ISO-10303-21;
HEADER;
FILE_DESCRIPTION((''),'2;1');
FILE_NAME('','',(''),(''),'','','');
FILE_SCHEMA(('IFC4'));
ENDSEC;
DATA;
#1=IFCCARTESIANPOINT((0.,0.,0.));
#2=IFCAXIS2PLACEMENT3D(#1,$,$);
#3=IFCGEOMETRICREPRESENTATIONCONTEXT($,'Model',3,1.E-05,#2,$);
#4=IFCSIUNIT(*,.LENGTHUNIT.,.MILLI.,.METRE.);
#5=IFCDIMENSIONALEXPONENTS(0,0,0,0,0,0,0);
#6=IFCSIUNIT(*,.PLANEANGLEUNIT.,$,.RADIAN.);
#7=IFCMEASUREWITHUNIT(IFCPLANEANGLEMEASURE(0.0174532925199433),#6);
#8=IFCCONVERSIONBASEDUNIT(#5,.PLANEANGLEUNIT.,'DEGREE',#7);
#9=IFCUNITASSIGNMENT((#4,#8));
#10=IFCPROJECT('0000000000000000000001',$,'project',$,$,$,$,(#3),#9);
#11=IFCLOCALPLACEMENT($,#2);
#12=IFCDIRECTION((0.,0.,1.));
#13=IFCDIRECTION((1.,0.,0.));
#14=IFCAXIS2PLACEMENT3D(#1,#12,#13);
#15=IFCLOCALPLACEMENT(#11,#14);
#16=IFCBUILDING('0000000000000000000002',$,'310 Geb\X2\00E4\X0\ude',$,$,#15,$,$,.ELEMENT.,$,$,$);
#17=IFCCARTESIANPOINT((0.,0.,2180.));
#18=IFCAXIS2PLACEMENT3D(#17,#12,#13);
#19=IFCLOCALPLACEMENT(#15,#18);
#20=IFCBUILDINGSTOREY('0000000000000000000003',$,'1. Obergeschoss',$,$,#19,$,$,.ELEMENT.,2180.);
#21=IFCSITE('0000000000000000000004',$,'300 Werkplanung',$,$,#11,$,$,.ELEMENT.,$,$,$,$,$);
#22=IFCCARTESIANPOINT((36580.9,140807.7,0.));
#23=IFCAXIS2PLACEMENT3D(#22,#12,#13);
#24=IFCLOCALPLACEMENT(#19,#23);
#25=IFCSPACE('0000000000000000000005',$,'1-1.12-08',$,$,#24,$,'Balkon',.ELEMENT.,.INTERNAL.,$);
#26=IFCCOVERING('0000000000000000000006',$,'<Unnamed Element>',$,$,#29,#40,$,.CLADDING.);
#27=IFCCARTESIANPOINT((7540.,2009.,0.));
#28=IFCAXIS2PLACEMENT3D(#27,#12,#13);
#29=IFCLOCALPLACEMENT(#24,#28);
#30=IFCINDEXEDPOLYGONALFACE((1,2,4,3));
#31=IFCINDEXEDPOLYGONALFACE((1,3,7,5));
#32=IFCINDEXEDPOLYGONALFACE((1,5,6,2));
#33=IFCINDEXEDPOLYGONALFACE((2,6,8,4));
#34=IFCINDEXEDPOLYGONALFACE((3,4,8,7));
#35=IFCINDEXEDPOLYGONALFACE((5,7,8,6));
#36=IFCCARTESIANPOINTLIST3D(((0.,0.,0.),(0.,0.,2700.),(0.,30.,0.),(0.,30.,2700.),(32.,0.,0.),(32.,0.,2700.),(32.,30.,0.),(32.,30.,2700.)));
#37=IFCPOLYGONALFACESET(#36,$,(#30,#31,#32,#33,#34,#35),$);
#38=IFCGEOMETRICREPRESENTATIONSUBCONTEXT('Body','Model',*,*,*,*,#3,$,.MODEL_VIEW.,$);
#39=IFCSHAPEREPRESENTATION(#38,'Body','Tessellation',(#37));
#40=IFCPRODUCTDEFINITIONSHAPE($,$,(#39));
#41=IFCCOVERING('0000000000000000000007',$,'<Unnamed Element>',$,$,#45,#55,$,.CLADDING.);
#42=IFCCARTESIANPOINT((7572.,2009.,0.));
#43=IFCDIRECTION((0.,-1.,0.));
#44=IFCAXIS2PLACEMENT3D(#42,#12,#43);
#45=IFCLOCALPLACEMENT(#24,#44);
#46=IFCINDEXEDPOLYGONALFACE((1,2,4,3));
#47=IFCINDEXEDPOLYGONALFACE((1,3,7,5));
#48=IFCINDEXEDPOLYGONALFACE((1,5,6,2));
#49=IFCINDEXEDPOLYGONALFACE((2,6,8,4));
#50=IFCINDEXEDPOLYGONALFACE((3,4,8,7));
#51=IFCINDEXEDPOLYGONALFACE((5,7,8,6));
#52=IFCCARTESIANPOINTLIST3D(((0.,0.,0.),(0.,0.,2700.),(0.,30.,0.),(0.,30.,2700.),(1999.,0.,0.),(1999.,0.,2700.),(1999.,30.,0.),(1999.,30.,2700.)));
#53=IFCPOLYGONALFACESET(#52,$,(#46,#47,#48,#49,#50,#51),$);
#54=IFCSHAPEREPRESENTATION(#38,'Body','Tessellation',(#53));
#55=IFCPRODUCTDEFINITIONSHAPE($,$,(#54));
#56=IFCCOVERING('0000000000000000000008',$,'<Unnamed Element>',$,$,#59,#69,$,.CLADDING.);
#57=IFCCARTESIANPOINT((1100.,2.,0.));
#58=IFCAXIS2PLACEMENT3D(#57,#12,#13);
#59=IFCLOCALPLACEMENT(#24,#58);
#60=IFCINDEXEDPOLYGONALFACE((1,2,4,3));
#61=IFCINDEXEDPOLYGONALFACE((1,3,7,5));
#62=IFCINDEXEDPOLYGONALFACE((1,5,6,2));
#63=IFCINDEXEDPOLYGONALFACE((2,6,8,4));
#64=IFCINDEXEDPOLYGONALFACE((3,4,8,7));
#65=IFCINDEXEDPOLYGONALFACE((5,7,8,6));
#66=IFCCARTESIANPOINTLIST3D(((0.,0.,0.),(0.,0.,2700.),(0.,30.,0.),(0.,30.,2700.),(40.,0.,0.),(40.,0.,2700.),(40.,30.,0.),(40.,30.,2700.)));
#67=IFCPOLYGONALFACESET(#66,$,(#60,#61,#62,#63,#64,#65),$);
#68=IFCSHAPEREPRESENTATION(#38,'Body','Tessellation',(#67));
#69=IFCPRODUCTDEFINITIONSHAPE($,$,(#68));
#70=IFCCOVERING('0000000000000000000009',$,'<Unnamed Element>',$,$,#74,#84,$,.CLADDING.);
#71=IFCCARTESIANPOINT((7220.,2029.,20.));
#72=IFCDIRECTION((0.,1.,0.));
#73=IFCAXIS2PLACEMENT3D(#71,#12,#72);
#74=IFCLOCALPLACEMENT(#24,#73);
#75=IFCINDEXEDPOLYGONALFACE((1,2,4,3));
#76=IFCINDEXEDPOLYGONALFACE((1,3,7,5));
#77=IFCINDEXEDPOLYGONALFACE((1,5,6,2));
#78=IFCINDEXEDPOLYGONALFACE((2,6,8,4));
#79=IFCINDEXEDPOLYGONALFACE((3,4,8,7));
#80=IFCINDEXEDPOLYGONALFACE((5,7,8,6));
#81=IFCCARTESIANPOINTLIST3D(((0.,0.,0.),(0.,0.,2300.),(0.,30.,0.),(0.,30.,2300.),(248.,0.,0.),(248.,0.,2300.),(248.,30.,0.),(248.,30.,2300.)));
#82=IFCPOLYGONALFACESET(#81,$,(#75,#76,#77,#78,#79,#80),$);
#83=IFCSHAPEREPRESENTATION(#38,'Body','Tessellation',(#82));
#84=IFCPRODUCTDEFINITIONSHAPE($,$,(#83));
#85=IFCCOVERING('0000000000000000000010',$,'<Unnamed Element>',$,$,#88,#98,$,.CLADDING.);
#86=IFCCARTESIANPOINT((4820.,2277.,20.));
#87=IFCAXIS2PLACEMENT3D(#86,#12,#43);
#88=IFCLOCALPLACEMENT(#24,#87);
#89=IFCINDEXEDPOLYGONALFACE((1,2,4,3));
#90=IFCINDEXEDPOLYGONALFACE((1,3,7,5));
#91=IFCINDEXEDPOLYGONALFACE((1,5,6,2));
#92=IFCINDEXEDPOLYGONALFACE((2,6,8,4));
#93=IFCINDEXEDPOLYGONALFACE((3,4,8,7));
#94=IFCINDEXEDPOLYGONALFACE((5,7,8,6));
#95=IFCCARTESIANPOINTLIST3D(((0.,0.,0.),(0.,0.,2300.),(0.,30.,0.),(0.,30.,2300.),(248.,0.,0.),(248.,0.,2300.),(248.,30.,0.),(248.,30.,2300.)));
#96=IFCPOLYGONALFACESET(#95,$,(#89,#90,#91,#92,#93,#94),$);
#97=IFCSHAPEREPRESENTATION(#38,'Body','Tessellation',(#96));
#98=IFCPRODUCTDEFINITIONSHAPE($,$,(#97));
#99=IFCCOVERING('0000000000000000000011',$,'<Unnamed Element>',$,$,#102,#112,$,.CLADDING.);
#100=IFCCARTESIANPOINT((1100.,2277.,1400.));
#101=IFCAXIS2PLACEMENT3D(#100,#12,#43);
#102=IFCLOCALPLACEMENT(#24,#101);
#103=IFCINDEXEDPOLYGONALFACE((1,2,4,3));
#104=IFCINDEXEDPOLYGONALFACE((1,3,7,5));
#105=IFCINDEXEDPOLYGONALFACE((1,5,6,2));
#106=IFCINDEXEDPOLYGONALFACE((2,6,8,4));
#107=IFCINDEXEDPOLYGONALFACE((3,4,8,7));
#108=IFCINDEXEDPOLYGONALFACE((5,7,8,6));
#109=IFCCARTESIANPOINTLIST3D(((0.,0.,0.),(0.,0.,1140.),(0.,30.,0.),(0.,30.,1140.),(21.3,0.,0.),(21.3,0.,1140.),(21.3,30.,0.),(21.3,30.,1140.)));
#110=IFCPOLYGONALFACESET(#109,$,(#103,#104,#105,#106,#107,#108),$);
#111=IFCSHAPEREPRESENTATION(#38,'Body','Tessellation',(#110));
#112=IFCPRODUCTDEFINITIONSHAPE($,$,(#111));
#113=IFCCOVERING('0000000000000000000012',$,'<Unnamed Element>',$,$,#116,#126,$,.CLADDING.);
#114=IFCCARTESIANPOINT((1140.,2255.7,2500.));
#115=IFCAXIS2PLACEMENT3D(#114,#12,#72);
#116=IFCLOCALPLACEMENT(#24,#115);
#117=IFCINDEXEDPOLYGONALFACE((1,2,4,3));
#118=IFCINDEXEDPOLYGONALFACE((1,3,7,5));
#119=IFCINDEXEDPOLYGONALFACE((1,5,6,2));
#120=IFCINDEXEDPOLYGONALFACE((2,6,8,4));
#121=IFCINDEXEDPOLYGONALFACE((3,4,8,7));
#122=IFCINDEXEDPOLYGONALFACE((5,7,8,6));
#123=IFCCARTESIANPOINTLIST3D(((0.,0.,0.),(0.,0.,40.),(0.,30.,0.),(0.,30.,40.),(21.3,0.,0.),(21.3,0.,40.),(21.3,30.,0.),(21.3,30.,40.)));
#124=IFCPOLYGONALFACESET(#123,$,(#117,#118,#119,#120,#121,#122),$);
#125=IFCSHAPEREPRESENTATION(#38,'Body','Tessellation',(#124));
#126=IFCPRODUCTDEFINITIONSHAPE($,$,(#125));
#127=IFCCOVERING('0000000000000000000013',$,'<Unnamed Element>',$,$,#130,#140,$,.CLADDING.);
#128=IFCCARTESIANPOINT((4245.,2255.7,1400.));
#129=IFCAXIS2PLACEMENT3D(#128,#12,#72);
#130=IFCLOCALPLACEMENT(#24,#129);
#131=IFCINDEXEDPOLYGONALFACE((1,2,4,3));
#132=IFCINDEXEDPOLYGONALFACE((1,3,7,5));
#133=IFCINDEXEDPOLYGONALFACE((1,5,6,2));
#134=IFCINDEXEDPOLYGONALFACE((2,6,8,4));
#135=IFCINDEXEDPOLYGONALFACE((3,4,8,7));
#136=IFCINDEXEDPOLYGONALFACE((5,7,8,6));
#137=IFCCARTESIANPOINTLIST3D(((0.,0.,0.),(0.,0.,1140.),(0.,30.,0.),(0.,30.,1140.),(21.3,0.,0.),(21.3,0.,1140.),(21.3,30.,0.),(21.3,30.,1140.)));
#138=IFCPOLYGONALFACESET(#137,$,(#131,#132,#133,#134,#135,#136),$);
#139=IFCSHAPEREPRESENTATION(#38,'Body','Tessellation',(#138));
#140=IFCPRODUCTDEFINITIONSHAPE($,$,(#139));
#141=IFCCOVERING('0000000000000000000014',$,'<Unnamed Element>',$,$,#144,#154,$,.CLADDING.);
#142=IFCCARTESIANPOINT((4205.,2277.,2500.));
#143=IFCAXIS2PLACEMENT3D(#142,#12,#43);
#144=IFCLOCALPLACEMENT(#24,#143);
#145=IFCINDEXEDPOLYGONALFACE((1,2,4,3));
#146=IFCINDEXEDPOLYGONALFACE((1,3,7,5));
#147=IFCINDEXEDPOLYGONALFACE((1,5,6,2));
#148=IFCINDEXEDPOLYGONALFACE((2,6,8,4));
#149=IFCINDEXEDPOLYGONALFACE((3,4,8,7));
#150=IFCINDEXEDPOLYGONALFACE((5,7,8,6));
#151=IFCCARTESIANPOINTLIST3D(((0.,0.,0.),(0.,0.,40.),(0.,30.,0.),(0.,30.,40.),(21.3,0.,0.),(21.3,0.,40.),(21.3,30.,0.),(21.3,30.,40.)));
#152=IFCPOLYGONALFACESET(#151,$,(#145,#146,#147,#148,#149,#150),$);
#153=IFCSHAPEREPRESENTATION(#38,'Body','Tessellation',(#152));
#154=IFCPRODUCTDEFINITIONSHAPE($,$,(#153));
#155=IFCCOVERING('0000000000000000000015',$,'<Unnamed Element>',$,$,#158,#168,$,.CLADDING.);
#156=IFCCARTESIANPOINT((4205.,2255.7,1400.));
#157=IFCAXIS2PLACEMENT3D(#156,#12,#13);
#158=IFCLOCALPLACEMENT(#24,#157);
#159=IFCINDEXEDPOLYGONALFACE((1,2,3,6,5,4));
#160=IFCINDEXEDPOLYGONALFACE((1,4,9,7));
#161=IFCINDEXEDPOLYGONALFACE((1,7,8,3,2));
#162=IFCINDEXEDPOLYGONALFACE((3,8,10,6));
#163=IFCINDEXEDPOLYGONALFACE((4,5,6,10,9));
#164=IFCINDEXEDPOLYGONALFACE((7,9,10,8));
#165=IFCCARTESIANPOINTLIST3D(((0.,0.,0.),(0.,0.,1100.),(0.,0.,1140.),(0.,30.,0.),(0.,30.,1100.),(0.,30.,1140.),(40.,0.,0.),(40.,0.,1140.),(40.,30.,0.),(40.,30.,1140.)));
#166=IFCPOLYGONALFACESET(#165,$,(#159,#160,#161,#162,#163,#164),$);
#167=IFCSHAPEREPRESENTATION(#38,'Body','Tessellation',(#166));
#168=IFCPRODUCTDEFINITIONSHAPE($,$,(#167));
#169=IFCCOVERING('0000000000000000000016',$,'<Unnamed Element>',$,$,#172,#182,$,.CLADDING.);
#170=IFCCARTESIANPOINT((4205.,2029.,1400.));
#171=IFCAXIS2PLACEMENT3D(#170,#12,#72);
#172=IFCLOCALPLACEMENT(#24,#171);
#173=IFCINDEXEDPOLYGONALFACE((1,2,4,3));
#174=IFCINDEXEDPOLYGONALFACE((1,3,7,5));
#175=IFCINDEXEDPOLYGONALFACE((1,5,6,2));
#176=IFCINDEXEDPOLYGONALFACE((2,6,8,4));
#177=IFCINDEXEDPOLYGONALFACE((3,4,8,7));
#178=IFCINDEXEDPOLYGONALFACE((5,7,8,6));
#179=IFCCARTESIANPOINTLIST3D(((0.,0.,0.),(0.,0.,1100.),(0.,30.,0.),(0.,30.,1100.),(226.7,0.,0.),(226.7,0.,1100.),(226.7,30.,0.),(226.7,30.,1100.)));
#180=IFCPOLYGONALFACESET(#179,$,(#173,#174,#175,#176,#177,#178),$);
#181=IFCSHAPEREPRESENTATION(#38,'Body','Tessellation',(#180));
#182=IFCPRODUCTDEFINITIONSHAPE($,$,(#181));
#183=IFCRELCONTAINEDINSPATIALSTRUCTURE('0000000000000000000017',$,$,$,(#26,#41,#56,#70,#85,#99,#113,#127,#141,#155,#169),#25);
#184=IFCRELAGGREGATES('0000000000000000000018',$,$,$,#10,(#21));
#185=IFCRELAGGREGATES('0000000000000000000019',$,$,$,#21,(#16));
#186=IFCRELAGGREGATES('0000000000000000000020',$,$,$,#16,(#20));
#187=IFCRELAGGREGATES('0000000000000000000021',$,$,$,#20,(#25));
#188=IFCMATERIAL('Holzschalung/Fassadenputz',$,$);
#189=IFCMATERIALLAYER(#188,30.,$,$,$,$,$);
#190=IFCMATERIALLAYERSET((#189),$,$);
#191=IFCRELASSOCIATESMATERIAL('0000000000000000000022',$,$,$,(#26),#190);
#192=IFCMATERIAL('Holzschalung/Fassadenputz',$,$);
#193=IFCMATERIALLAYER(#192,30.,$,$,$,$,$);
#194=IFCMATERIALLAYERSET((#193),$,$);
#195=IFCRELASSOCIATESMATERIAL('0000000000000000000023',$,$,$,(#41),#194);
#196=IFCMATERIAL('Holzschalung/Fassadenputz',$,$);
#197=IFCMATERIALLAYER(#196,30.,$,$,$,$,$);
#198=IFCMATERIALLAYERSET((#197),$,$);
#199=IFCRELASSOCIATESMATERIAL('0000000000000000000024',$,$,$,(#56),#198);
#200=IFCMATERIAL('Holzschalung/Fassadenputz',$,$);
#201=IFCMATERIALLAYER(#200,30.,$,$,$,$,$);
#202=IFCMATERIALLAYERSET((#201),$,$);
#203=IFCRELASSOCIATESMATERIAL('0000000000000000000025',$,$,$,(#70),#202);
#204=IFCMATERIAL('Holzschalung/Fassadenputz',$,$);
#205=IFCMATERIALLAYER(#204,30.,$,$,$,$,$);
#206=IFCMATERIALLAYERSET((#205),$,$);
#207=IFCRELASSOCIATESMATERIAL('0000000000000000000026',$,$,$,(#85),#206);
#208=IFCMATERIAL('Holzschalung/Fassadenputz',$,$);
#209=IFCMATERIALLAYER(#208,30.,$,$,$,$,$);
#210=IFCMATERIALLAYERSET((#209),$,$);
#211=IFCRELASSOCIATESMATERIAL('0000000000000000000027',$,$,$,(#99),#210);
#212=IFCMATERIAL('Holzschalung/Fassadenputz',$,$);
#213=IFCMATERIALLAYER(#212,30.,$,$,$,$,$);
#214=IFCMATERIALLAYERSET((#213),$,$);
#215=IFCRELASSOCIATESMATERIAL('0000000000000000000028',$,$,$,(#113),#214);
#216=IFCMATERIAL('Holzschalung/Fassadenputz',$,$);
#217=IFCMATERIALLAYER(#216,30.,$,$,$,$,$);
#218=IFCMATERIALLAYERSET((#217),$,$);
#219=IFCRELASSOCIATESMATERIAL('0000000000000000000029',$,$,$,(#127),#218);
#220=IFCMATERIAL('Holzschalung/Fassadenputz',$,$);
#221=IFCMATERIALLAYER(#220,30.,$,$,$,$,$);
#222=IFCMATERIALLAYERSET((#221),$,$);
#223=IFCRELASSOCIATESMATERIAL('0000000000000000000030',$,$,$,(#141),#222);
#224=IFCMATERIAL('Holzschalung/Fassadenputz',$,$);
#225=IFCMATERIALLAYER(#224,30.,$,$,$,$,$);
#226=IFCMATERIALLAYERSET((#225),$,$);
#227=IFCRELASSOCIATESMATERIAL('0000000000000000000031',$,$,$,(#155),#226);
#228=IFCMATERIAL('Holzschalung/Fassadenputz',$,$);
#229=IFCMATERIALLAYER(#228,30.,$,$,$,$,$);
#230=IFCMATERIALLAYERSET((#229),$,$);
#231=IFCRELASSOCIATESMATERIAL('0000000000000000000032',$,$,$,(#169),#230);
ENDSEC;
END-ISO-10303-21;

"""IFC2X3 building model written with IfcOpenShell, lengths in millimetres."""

from ifc_helpers import new_model, entity, si_unit, converted_unit, frame, frame_2d, origin, origin_with_axes, place, context, subcontext, project, spatial, polyline, rectangle, outline, extrude, material, layer, layer_set, layer_usage, element, save


model = new_model("IFC2X3")

# Units and contexts
model_context = context("Model", 3, precision=1e-05, world=origin())
body_context = subcontext(model_context, "Body", "Model", "MODEL_VIEW")
ifc_project = project(units=[si_unit("LENGTHUNIT", "METRE", prefix="MILLI"), converted_unit("PLANEANGLEUNIT", "DEGREE", entity("IfcPlaneAngleMeasure", 0.0174532925199433), si_unit("PLANEANGLEUNIT", "RADIAN"), dimensions=[0, 0, 0, 0, 0, 0, 0])], contexts=[model_context])

# Site, building, storey
site_placement = place(None, origin())
site = spatial("IfcSite", under=ifc_project, at=site_placement, Name="300 Werkplanung", CompositionType="ELEMENT")
building_placement = place(site_placement, origin_with_axes())
building = spatial("IfcBuilding", under=site, at=building_placement, Name="310 Gebäude", CompositionType="ELEMENT")
storey_placement = place(building_placement, frame((0.0, 0.0, 2180.0), z_axis=(0.0, 0.0, 1.0), x_axis=(1.0, 0.0, 0.0)))
storey = spatial("IfcBuildingStorey", under=building, at=storey_placement, Name="1. Obergeschoss", CompositionType="ELEMENT", Elevation=2180.0)

# Shared definitions
space_1_placement = place(storey_placement, frame((36580.9, 140807.7, 0.0), z_axis=(0.0, 0.0, 1.0), x_axis=(1.0, 0.0, 0.0)))
space_1 = spatial("IfcSpace", under=storey, at=space_1_placement, Name="1-1.12-08", LongName="Balkon", CompositionType="ELEMENT", InteriorOrExteriorSpace="INTERNAL")

# Coverings
ifc_material_1 = material(Name="Holzschalung/Fassadenputz")
ifc_layer_1 = layer(ifc_material_1, 30.0)
ifc_layer_set_1 = layer_set([ifc_layer_1])
ifc_layer_usage_1 = layer_usage(ifc_layer_set_1, "AXIS3", "POSITIVE", 0.0)
covering_1_placement = place(space_1_placement, frame((7540.0, 2009.0, 0.0), z_axis=(0.0, 0.0, 1.0), x_axis=(1.0, 0.0, 0.0)))
element("IfcCovering", 1, at=covering_1_placement, inside=space_1, material=ifc_layer_usage_1, Name="<Unnamed Element>", PredefinedType="CLADDING", context=body_context, shape_type="SweptSolid", body=[
    extrude(rectangle(XDim=32.0, YDim=2700.0, at=frame_2d((-16.0, -1350.0), x_axis=(-1.0, 0.0))), frame((32.0, 0.0, 0.0), z_axis=(0.0, 1.0, 0.0), x_axis=(1.0, 0.0, 0.0)), (0.0, 0.0, 1.0), 30.0),
])
ifc_material_2 = material(Name="Holzschalung/Fassadenputz")
ifc_layer_2 = layer(ifc_material_2, 30.0)
ifc_layer_set_2 = layer_set([ifc_layer_2])
ifc_layer_usage_2 = layer_usage(ifc_layer_set_2, "AXIS3", "POSITIVE", 0.0)
covering_2_placement = place(space_1_placement, frame((7572.0, 2009.0, 0.0), z_axis=(0.0, 0.0, 1.0), x_axis=(0.0, -1.0, 0.0)))
element("IfcCovering", 2, at=covering_2_placement, inside=space_1, material=ifc_layer_usage_2, Name="<Unnamed Element>", PredefinedType="CLADDING", context=body_context, shape_type="SweptSolid", body=[
    extrude(rectangle(XDim=1999.0, YDim=2700.0, at=frame_2d((-999.5, -1350.0), x_axis=(-1.0, 0.0))), frame((1999.0, 0.0, 0.0), z_axis=(0.0, 1.0, 0.0), x_axis=(1.0, 0.0, 0.0)), (0.0, 0.0, 1.0), 30.0),
])
ifc_material_3 = material(Name="Holzschalung/Fassadenputz")
ifc_layer_3 = layer(ifc_material_3, 30.0)
ifc_layer_set_3 = layer_set([ifc_layer_3])
ifc_layer_usage_3 = layer_usage(ifc_layer_set_3, "AXIS3", "POSITIVE", 0.0)
covering_3_placement = place(space_1_placement, frame((1100.0, 2.0, 0.0), z_axis=(0.0, 0.0, 1.0), x_axis=(1.0, 0.0, 0.0)))
element("IfcCovering", 3, at=covering_3_placement, inside=space_1, material=ifc_layer_usage_3, Name="<Unnamed Element>", PredefinedType="CLADDING", context=body_context, shape_type="SweptSolid", body=[
    extrude(rectangle(XDim=40.0, YDim=2700.0, at=frame_2d((-20.0, -1350.0), x_axis=(-1.0, 0.0))), frame((40.0, 0.0, 0.0), z_axis=(0.0, 1.0, 0.0), x_axis=(1.0, 0.0, 0.0)), (0.0, 0.0, 1.0), 30.0),
])
ifc_material_4 = material(Name="Holzschalung/Fassadenputz")
ifc_layer_4 = layer(ifc_material_4, 30.0)
ifc_layer_set_4 = layer_set([ifc_layer_4])
ifc_layer_usage_4 = layer_usage(ifc_layer_set_4, "AXIS3", "POSITIVE", 0.0)
covering_4_placement = place(space_1_placement, frame((7220.0, 2029.0, 20.0), z_axis=(0.0, 0.0, 1.0), x_axis=(0.0, 1.0, 0.0)))
element("IfcCovering", 4, at=covering_4_placement, inside=space_1, material=ifc_layer_usage_4, Name="<Unnamed Element>", PredefinedType="CLADDING", context=body_context, shape_type="SweptSolid", body=[
    extrude(rectangle(XDim=248.0, YDim=2300.0, at=frame_2d((-124.0, -1150.0), x_axis=(-1.0, 0.0))), frame((248.0, 0.0, 0.0), z_axis=(0.0, 1.0, 0.0), x_axis=(1.0, 0.0, 0.0)), (0.0, 0.0, 1.0), 30.0),
])
ifc_material_5 = material(Name="Holzschalung/Fassadenputz")
ifc_layer_5 = layer(ifc_material_5, 30.0)
ifc_layer_set_5 = layer_set([ifc_layer_5])
ifc_layer_usage_5 = layer_usage(ifc_layer_set_5, "AXIS3", "POSITIVE", 0.0)
covering_5_placement = place(space_1_placement, frame((4820.0, 2277.0, 20.0), z_axis=(0.0, 0.0, 1.0), x_axis=(0.0, -1.0, 0.0)))
element("IfcCovering", 5, at=covering_5_placement, inside=space_1, material=ifc_layer_usage_5, Name="<Unnamed Element>", PredefinedType="CLADDING", context=body_context, shape_type="SweptSolid", body=[
    extrude(rectangle(XDim=248.0, YDim=2300.0, at=frame_2d((-124.0, -1150.0), x_axis=(-1.0, 0.0))), frame((248.0, 0.0, 0.0), z_axis=(0.0, 1.0, 0.0), x_axis=(1.0, 0.0, 0.0)), (0.0, 0.0, 1.0), 30.0),
])
ifc_material_6 = material(Name="Holzschalung/Fassadenputz")
ifc_layer_6 = layer(ifc_material_6, 30.0)
ifc_layer_set_6 = layer_set([ifc_layer_6])
ifc_layer_usage_6 = layer_usage(ifc_layer_set_6, "AXIS3", "POSITIVE", 0.0)
covering_6_placement = place(space_1_placement, frame((1100.0, 2277.0, 1400.0), z_axis=(0.0, 0.0, 1.0), x_axis=(0.0, -1.0, 0.0)))
element("IfcCovering", 6, at=covering_6_placement, inside=space_1, material=ifc_layer_usage_6, Name="<Unnamed Element>", PredefinedType="CLADDING", context=body_context, shape_type="SweptSolid", body=[
    extrude(rectangle(XDim=1140.0, YDim=21.3, at=frame_2d((-10.7, 570.0), x_axis=(0.0, 1.0))), frame((21.3, 0.0, 1140.0), z_axis=(0.0, 1.0, 0.0), x_axis=(1.0, 0.0, 0.0)), (0.0, 0.0, 1.0), 30.0),
])
ifc_material_7 = material(Name="Holzschalung/Fassadenputz")
ifc_layer_7 = layer(ifc_material_7, 30.0)
ifc_layer_set_7 = layer_set([ifc_layer_7])
ifc_layer_usage_7 = layer_usage(ifc_layer_set_7, "AXIS3", "POSITIVE", 0.0)
covering_7_placement = place(space_1_placement, frame((1140.0, 2255.7, 2500.0), z_axis=(0.0, 0.0, 1.0), x_axis=(0.0, 1.0, 0.0)))
element("IfcCovering", 7, at=covering_7_placement, inside=space_1, material=ifc_layer_usage_7, Name="<Unnamed Element>", PredefinedType="CLADDING", context=body_context, shape_type="SweptSolid", body=[
    extrude(rectangle(XDim=21.3, YDim=40.0, at=frame_2d((-10.7, -20.0), x_axis=(-1.0, 0.0))), frame((21.3, 0.0, 0.0), z_axis=(0.0, 1.0, 0.0), x_axis=(1.0, 0.0, 0.0)), (0.0, 0.0, 1.0), 30.0),
])
ifc_material_8 = material(Name="Holzschalung/Fassadenputz")
ifc_layer_8 = layer(ifc_material_8, 30.0)
ifc_layer_set_8 = layer_set([ifc_layer_8])
ifc_layer_usage_8 = layer_usage(ifc_layer_set_8, "AXIS3", "POSITIVE", 0.0)
covering_8_placement = place(space_1_placement, frame((4245.0, 2255.7, 1400.0), z_axis=(0.0, 0.0, 1.0), x_axis=(0.0, 1.0, 0.0)))
element("IfcCovering", 8, at=covering_8_placement, inside=space_1, material=ifc_layer_usage_8, Name="<Unnamed Element>", PredefinedType="CLADDING", context=body_context, shape_type="SweptSolid", body=[
    extrude(rectangle(XDim=1140.0, YDim=21.3, at=frame_2d((-10.6, 570.0), x_axis=(0.0, 1.0))), frame((21.3, 0.0, 1140.0), z_axis=(0.0, 1.0, 0.0), x_axis=(1.0, 0.0, 0.0)), (0.0, 0.0, 1.0), 30.0),
])
ifc_material_9 = material(Name="Holzschalung/Fassadenputz")
ifc_layer_9 = layer(ifc_material_9, 30.0)
ifc_layer_set_9 = layer_set([ifc_layer_9])
ifc_layer_usage_9 = layer_usage(ifc_layer_set_9, "AXIS3", "POSITIVE", 0.0)
covering_9_placement = place(space_1_placement, frame((4205.0, 2277.0, 2500.0), z_axis=(0.0, 0.0, 1.0), x_axis=(0.0, -1.0, 0.0)))
element("IfcCovering", 9, at=covering_9_placement, inside=space_1, material=ifc_layer_usage_9, Name="<Unnamed Element>", PredefinedType="CLADDING", context=body_context, shape_type="SweptSolid", body=[
    extrude(rectangle(XDim=21.3, YDim=40.0, at=frame_2d((-10.6, -20.0), x_axis=(-1.0, 0.0))), frame((21.3, 0.0, 0.0), z_axis=(0.0, 1.0, 0.0), x_axis=(1.0, 0.0, 0.0)), (0.0, 0.0, 1.0), 30.0),
])
ifc_material_10 = material(Name="Holzschalung/Fassadenputz")
ifc_layer_10 = layer(ifc_material_10, 30.0)
ifc_layer_set_10 = layer_set([ifc_layer_10])
ifc_layer_usage_10 = layer_usage(ifc_layer_set_10, "AXIS3", "POSITIVE", 0.0)
covering_10_placement = place(space_1_placement, frame((4205.0, 2255.7, 1400.0), z_axis=(0.0, 0.0, 1.0), x_axis=(1.0, 0.0, 0.0)))
element("IfcCovering", 10, at=covering_10_placement, inside=space_1, material=ifc_layer_usage_10, Name="<Unnamed Element>", PredefinedType="CLADDING", context=body_context, shape_type="SweptSolid", body=[
    extrude(outline(polyline([(0.0, 0.0), (40.0, 0.0), (40.0, -1140.0), (0.0, -1140.0), (0.0, -1100.0), (0.0, 0.0)])), frame((0.0, 0.0, 0.0), z_axis=(0.0, 1.0, 0.0), x_axis=(1.0, 0.0, 0.0)), (0.0, 0.0, 1.0), 30.0),
])
ifc_material_11 = material(Name="Holzschalung/Fassadenputz")
ifc_layer_11 = layer(ifc_material_11, 30.0)
ifc_layer_set_11 = layer_set([ifc_layer_11])
ifc_layer_usage_11 = layer_usage(ifc_layer_set_11, "AXIS3", "POSITIVE", 0.0)
covering_11_placement = place(space_1_placement, frame((4205.0, 2029.0, 1400.0), z_axis=(0.0, 0.0, 1.0), x_axis=(0.0, 1.0, 0.0)))
element("IfcCovering", 11, at=covering_11_placement, inside=space_1, material=ifc_layer_usage_11, Name="<Unnamed Element>", PredefinedType="CLADDING", context=body_context, shape_type="SweptSolid", body=[
    extrude(rectangle(XDim=226.7, YDim=1100.0, at=frame_2d((-113.4, -550.0), x_axis=(-1.0, 0.0))), frame((226.7, 0.0, 0.0), z_axis=(0.0, 1.0, 0.0), x_axis=(1.0, 0.0, 0.0)), (0.0, 0.0, 1.0), 30.0),
])

save(model, "model.ifc")
